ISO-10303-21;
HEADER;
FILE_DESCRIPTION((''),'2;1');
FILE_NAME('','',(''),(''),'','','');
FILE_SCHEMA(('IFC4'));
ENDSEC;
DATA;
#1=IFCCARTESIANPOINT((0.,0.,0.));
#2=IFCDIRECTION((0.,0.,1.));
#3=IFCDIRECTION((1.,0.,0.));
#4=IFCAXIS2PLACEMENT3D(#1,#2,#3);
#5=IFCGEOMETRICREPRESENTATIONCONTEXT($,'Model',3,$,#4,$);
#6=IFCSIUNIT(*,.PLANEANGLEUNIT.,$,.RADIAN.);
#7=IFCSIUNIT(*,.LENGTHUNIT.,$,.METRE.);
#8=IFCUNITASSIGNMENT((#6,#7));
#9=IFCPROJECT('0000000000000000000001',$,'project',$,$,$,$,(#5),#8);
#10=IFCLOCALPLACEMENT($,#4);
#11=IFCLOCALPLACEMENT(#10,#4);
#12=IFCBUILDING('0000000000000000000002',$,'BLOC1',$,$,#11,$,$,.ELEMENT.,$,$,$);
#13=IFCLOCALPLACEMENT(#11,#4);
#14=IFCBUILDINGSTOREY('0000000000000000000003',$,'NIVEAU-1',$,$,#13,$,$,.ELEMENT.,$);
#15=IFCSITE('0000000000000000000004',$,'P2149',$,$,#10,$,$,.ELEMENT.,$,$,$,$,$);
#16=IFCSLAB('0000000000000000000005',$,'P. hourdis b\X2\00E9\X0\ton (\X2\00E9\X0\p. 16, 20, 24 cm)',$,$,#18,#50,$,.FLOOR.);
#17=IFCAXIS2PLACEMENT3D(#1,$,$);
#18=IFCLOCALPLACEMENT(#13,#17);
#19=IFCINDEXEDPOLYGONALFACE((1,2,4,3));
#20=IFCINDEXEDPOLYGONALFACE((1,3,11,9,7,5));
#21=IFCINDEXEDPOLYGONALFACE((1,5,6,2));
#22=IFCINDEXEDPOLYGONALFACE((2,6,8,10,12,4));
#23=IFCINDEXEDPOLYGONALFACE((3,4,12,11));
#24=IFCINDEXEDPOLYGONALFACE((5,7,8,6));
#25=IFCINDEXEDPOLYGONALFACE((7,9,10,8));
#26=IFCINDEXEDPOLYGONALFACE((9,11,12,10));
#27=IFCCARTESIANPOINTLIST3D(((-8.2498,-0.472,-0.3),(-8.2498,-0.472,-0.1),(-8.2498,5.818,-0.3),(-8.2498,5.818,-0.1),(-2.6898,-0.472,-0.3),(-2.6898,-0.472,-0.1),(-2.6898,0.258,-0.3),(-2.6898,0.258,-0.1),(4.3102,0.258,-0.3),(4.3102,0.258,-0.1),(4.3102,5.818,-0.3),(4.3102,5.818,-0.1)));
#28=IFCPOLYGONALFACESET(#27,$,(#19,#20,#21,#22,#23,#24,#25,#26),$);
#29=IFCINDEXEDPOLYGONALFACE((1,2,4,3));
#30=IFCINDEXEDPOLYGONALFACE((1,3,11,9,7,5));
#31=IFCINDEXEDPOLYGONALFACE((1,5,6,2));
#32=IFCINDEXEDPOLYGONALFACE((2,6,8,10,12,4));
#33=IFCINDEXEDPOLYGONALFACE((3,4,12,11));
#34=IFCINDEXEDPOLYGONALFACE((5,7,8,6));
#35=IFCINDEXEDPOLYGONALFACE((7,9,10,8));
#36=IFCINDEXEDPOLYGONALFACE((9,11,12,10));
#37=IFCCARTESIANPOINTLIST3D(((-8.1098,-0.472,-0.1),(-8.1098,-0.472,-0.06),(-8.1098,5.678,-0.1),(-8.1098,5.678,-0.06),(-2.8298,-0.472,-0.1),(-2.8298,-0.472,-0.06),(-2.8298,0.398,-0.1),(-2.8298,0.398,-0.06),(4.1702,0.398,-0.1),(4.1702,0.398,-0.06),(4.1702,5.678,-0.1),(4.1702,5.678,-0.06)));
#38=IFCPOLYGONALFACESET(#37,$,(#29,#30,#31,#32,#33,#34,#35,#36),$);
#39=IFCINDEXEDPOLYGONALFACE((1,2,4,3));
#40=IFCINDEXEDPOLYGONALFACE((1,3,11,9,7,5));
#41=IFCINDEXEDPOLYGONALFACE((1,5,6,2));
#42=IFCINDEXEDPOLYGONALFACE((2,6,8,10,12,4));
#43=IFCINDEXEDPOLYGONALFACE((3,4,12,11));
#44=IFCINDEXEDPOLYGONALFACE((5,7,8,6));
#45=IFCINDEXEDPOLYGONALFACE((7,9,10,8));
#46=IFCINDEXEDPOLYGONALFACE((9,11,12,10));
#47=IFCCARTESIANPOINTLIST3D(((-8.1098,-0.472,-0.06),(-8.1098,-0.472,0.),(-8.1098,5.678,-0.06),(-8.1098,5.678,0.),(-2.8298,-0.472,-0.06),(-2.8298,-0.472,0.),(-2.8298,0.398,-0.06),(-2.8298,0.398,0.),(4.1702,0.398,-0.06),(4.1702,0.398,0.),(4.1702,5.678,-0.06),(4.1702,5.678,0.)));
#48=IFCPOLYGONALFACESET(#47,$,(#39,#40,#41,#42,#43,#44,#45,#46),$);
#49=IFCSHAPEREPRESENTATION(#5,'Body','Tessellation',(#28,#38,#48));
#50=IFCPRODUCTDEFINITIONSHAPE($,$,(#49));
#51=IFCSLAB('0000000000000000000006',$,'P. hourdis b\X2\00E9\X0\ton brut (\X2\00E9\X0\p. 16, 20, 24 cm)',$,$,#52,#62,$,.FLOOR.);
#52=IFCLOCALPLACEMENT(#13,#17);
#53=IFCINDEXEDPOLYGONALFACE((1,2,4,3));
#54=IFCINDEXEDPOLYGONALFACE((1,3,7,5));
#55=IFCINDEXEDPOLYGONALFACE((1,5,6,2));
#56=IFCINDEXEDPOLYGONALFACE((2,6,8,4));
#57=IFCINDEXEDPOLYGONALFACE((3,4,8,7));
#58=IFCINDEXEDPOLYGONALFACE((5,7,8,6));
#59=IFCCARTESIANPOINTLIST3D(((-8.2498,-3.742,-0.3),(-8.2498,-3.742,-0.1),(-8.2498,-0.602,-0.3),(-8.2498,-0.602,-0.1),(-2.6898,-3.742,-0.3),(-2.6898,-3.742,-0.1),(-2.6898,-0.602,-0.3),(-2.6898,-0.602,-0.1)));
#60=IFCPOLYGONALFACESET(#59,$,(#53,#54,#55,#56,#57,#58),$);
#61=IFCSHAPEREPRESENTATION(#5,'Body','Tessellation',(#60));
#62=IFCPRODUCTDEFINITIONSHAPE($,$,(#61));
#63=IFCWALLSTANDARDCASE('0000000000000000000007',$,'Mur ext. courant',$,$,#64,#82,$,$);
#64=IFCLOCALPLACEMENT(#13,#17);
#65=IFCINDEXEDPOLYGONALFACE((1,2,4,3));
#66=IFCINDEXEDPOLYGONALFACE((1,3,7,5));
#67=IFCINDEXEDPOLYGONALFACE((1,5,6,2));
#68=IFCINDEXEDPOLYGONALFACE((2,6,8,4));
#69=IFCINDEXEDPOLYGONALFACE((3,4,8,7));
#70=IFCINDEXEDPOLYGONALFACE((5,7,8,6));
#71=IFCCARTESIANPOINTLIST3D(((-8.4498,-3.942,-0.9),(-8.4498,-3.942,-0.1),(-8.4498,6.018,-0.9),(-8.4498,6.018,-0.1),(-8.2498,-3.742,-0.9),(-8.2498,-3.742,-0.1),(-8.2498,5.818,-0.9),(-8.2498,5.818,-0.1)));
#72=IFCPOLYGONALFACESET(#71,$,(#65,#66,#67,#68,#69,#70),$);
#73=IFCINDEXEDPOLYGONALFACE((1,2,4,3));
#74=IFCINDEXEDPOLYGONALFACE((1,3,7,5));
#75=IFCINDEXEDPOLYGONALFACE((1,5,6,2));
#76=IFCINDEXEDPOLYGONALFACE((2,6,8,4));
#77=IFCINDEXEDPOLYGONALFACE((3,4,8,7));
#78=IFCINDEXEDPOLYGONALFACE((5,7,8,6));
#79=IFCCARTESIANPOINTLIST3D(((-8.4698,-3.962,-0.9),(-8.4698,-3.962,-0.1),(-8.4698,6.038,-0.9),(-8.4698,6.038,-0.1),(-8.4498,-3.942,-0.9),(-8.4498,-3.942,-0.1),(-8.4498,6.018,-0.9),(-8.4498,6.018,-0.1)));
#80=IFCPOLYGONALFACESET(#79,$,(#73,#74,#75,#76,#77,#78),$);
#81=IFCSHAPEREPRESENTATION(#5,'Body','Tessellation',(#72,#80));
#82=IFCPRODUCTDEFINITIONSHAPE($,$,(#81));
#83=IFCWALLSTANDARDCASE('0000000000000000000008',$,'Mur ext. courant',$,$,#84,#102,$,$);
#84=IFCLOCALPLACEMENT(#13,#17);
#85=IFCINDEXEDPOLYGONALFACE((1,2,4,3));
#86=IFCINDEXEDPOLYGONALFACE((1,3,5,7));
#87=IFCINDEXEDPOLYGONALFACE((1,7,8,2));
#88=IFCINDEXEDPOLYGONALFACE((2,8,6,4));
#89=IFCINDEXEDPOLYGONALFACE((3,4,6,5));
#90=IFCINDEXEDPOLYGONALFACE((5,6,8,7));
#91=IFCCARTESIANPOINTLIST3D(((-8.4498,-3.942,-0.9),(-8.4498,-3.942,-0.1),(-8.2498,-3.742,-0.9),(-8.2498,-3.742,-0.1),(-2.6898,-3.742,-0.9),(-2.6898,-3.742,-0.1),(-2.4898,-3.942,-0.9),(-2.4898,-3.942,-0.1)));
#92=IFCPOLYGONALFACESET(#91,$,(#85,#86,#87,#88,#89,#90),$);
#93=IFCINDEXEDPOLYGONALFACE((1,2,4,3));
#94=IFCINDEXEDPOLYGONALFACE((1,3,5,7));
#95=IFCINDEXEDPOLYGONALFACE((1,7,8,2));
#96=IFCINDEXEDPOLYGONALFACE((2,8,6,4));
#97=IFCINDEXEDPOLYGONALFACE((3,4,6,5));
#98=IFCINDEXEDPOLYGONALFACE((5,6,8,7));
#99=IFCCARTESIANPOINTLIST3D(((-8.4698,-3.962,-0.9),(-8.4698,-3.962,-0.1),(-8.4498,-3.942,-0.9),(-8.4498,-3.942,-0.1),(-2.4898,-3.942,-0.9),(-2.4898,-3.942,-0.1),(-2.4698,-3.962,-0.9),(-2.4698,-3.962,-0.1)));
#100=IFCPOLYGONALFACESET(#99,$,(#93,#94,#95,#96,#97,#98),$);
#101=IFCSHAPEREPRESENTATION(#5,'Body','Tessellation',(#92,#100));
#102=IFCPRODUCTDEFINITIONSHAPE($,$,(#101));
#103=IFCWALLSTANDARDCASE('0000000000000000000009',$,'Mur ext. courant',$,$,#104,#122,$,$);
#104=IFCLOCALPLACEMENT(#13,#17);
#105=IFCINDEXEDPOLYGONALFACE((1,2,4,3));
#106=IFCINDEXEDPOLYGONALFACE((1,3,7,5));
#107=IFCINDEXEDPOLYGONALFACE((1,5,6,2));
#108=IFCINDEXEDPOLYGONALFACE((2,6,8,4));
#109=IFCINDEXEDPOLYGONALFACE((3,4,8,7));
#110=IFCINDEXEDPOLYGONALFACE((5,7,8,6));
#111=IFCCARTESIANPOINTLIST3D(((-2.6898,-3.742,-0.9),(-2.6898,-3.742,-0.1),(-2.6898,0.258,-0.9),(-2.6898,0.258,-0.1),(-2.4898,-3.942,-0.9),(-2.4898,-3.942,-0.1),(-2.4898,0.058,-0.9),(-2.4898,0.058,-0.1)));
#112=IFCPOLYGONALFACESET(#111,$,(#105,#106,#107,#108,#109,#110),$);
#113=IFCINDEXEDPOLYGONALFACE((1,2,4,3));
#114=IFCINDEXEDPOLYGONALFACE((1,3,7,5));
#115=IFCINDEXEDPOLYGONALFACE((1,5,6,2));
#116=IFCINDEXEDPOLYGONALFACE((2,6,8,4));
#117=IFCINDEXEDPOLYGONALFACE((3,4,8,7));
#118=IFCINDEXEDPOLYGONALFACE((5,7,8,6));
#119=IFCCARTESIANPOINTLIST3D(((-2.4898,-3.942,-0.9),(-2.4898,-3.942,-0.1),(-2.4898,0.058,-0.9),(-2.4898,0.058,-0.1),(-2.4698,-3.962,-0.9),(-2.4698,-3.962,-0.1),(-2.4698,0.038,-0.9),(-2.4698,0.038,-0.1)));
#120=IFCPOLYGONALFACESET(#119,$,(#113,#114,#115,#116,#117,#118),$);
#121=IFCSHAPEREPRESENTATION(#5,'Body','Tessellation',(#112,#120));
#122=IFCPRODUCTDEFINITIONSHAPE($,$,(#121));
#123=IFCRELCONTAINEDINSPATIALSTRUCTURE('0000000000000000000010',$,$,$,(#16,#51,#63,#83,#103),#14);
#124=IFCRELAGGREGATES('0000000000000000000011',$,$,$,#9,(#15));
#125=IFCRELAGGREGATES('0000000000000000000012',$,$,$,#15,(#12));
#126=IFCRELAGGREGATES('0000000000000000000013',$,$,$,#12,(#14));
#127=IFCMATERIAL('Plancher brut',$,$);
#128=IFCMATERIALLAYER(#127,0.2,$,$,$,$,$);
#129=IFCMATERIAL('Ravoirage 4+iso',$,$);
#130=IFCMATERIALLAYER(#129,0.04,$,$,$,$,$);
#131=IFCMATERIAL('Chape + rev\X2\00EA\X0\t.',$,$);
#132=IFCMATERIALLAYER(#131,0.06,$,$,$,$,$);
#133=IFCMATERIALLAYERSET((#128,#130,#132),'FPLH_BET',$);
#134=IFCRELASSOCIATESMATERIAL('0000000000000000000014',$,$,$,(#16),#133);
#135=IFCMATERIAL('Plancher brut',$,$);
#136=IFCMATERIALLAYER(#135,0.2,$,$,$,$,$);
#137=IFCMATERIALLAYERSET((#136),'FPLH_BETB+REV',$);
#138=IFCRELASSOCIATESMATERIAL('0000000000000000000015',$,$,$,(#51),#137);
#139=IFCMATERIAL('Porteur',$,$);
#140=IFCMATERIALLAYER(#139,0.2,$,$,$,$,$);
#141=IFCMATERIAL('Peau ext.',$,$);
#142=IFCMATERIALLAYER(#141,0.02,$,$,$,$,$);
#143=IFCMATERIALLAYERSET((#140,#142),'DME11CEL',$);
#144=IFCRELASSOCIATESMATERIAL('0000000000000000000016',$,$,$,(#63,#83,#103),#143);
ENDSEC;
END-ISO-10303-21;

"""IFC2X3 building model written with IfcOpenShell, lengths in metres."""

from ifc_helpers import new_model, si_unit, point, frame, origin_with_axes, place, context, project, spatial, line_curve, trimmed, segment, composite_curve, outline, extrude, material, layer, layer_set, layer_usage, element, save


model = new_model("IFC2X3")

# Units and contexts
model_context = context("Model", 3, world=origin_with_axes())
ifc_project = project(units=[si_unit("PLANEANGLEUNIT", "RADIAN"), si_unit("LENGTHUNIT", "METRE")], contexts=[model_context])

# Site, building, storey
site_placement = place(None, origin_with_axes())
site = spatial("IfcSite", under=ifc_project, at=site_placement, Name="P2149", CompositionType="ELEMENT")
building_placement = place(site_placement, origin_with_axes())
building = spatial("IfcBuilding", under=site, at=building_placement, Name="BLOC1", CompositionType="ELEMENT")
storey_placement = place(building_placement, origin_with_axes())
storey = spatial("IfcBuildingStorey", under=building, at=storey_placement, Name="NIVEAU-1", CompositionType="ELEMENT")

# Slabs
ifc_material_1 = material(Name="Plancher brut")
ifc_layer_1 = layer(ifc_material_1, 0.2)
ifc_material_2 = material(Name="Ravoirage 4+iso")
ifc_layer_2 = layer(ifc_material_2, 0.04)
ifc_material_3 = material(Name="Chape + revêt.")
ifc_layer_3 = layer(ifc_material_3, 0.06)
ifc_layer_set_1 = layer_set([ifc_layer_1, ifc_layer_2, ifc_layer_3], Name="FPLH_BET")
ifc_layer_usage_1 = layer_usage(ifc_layer_set_1, "AXIS3", "POSITIVE", 0.0)
slab_1_placement = place(storey_placement, origin_with_axes())
element("IfcSlab", 1, at=slab_1_placement, inside=storey, material=ifc_layer_usage_1, Name="P. hourdis béton (ép. 16, 20, 24 cm)", PredefinedType="FLOOR", context=model_context, shape_type="SweptSolid", body=[
    extrude(outline(composite_curve([segment(trimmed(line_curve((-2.6898, 0.258), (1.0, 0.0), 7.0), [point((-2.6898, 0.258))], [point((4.3102, 0.258))], True, "CARTESIAN"), True, "CONTINUOUS"), segment(trimmed(line_curve((4.3102, 0.258), (0.0, 1.0), 5.56), [point((4.3102, 0.258))], [point((4.3102, 5.818))], True, "CARTESIAN"), True, "CONTINUOUS"), segment(trimmed(line_curve((4.3102, 5.818), (-1.0, 0.0), 12.56), [point((4.3102, 5.818))], [point((-8.2498, 5.818))], True, "CARTESIAN"), True, "CONTINUOUS"), segment(trimmed(line_curve((-8.2498, 5.818), (0.0, -1.0), 6.29), [point((-8.2498, 5.818))], [point((-8.2498, -0.472))], True, "CARTESIAN"), True, "CONTINUOUS"), segment(trimmed(line_curve((-8.2498, -0.472), (1.0, 0.0), 5.56), [point((-8.2498, -0.472))], [point((-2.6898, -0.472))], True, "CARTESIAN"), True, "CONTINUOUS"), segment(trimmed(line_curve((-2.6898, -0.472), (0.0, 1.0), 0.73), [point((-2.6898, -0.472))], [point((-2.6898, 0.258))], True, "CARTESIAN"), True, "CONTINUOUS")], self_intersect=False)), frame((0.0, 0.0, -0.3), z_axis=(0.0, 0.0, 1.0), x_axis=(1.0, 0.0, 0.0)), (0.0, 0.0, 1.0), 0.2),
    extrude(outline(composite_curve([segment(trimmed(line_curve((-2.8298, 0.398), (1.0, 0.0), 7.0), [point((-2.8298, 0.398))], [point((4.1702, 0.398))], True, "CARTESIAN"), True, "CONTINUOUS"), segment(trimmed(line_curve((4.1702, 0.398), (0.0, 1.0), 5.28), [point((4.1702, 0.398))], [point((4.1702, 5.678))], True, "CARTESIAN"), True, "CONTINUOUS"), segment(trimmed(line_curve((4.1702, 5.678), (-1.0, 0.0), 12.28), [point((4.1702, 5.678))], [point((-8.1098, 5.678))], True, "CARTESIAN"), True, "CONTINUOUS"), segment(trimmed(line_curve((-8.1098, 5.678), (0.0, -1.0), 6.15), [point((-8.1098, 5.678))], [point((-8.1098, -0.472))], True, "CARTESIAN"), True, "CONTINUOUS"), segment(trimmed(line_curve((-8.1098, -0.472), (1.0, 0.0), 5.28), [point((-8.1098, -0.472))], [point((-2.8298, -0.472))], True, "CARTESIAN"), True, "CONTINUOUS"), segment(trimmed(line_curve((-2.8298, -0.472), (0.0, 1.0), 0.87), [point((-2.8298, -0.472))], [point((-2.8298, 0.398))], True, "CARTESIAN"), True, "CONTINUOUS")], self_intersect=False)), frame((0.0, 0.0, -0.1), z_axis=(0.0, 0.0, 1.0), x_axis=(1.0, 0.0, 0.0)), (0.0, 0.0, 1.0), 0.04),
    extrude(outline(composite_curve([segment(trimmed(line_curve((-2.8298, 0.398), (1.0, 0.0), 7.0), [point((-2.8298, 0.398))], [point((4.1702, 0.398))], True, "CARTESIAN"), True, "CONTINUOUS"), segment(trimmed(line_curve((4.1702, 0.398), (0.0, 1.0), 5.28), [point((4.1702, 0.398))], [point((4.1702, 5.678))], True, "CARTESIAN"), True, "CONTINUOUS"), segment(trimmed(line_curve((4.1702, 5.678), (-1.0, 0.0), 12.28), [point((4.1702, 5.678))], [point((-8.1098, 5.678))], True, "CARTESIAN"), True, "CONTINUOUS"), segment(trimmed(line_curve((-8.1098, 5.678), (0.0, -1.0), 6.15), [point((-8.1098, 5.678))], [point((-8.1098, -0.472))], True, "CARTESIAN"), True, "CONTINUOUS"), segment(trimmed(line_curve((-8.1098, -0.472), (1.0, 0.0), 5.28), [point((-8.1098, -0.472))], [point((-2.8298, -0.472))], True, "CARTESIAN"), True, "CONTINUOUS"), segment(trimmed(line_curve((-2.8298, -0.472), (0.0, 1.0), 0.87), [point((-2.8298, -0.472))], [point((-2.8298, 0.398))], True, "CARTESIAN"), True, "CONTINUOUS")], self_intersect=False)), frame((0.0, 0.0, -0.06), z_axis=(0.0, 0.0, 1.0), x_axis=(1.0, 0.0, 0.0)), (0.0, 0.0, 1.0), 0.06),
])
ifc_material_4 = material(Name="Plancher brut")
ifc_layer_4 = layer(ifc_material_4, 0.2)
ifc_layer_set_2 = layer_set([ifc_layer_4], Name="FPLH_BETB+REV")
ifc_layer_usage_2 = layer_usage(ifc_layer_set_2, "AXIS3", "POSITIVE", 0.0)
slab_2_placement = place(storey_placement, origin_with_axes())
element("IfcSlab", 2, at=slab_2_placement, inside=storey, material=ifc_layer_usage_2, Name="P. hourdis béton brut (ép. 16, 20, 24 cm)", PredefinedType="FLOOR", context=model_context, shape_type="SweptSolid", body=[
    extrude(outline(composite_curve([segment(trimmed(line_curve((-8.2498, -3.742), (1.0, 0.0), 5.56), [point((-8.2498, -3.742))], [point((-2.6898, -3.742))], True, "CARTESIAN"), True, "CONTINUOUS"), segment(trimmed(line_curve((-2.6898, -3.742), (0.0, 1.0), 3.14), [point((-2.6898, -3.742))], [point((-2.6898, -0.602))], True, "CARTESIAN"), True, "CONTINUOUS"), segment(trimmed(line_curve((-2.6898, -0.602), (-1.0, 0.0), 5.56), [point((-2.6898, -0.602))], [point((-8.2498, -0.602))], True, "CARTESIAN"), True, "CONTINUOUS"), segment(trimmed(line_curve((-8.2498, -0.602), (0.0, -1.0), 3.14), [point((-8.2498, -0.602))], [point((-8.2498, -3.742))], True, "CARTESIAN"), True, "CONTINUOUS")], self_intersect=False)), frame((0.0, 0.0, -0.3), z_axis=(0.0, 0.0, 1.0), x_axis=(1.0, 0.0, 0.0)), (0.0, 0.0, 1.0), 0.2),
])

# Walls
ifc_material_5 = material(Name="Porteur")
ifc_layer_5 = layer(ifc_material_5, 0.2)
ifc_material_6 = material(Name="Peau ext.")
ifc_layer_6 = layer(ifc_material_6, 0.02)
ifc_layer_set_3 = layer_set([ifc_layer_5, ifc_layer_6], Name="DME11CEL")
ifc_layer_usage_3 = layer_usage(ifc_layer_set_3, "AXIS2", "POSITIVE", 0.0)
wall_1_placement = place(storey_placement, frame((-8.2498, -3.742, -0.9), z_axis=(0.0, 0.0, 1.0), x_axis=(0.0, 1.0, 0.0)))
element("IfcWallStandardCase", 3, at=wall_1_placement, inside=storey, material=ifc_layer_usage_3, Name="Mur ext. courant", context=model_context, shape_type="SweptSolid", body=[
    extrude(outline(composite_curve([segment(trimmed(line_curve((0.0, 0.0), (1.0, 0.0), 9.56), [point((0.0, 0.0))], [point((9.56, 0.0))], True, "CARTESIAN"), True, "CONTINUOUS"), segment(trimmed(line_curve((9.56, 0.0), (0.707107, 0.707107), 0.282843), [point((9.56, 0.0))], [point((9.76, 0.2))], True, "CARTESIAN"), True, "CONTINUOUS"), segment(trimmed(line_curve((9.76, 0.2), (-1.0, 0.0), 9.96), [point((9.76, 0.2))], [point((-0.2, 0.2))], True, "CARTESIAN"), True, "CONTINUOUS"), segment(trimmed(line_curve((-0.2, 0.2), (0.707107, -0.707107), 0.282843), [point((-0.2, 0.2))], [point((0.0, 0.0))], True, "CARTESIAN"), True, "CONTINUOUS")], self_intersect=False)), origin_with_axes(), (0.0, 0.0, 1.0), 0.8),
    extrude(outline(composite_curve([segment(trimmed(line_curve((-0.2, 0.2), (1.0, 0.0), 9.96), [point((-0.2, 0.2))], [point((9.76, 0.2))], True, "CARTESIAN"), True, "CONTINUOUS"), segment(trimmed(line_curve((9.76, 0.2), (0.707107, 0.707107), 0.028284), [point((9.76, 0.2))], [point((9.78, 0.22))], True, "CARTESIAN"), True, "CONTINUOUS"), segment(trimmed(line_curve((9.78, 0.22), (-1.0, 0.0), 10.0), [point((9.78, 0.22))], [point((-0.22, 0.22))], True, "CARTESIAN"), True, "CONTINUOUS"), segment(trimmed(line_curve((-0.22, 0.22), (0.707107, -0.707107), 0.028284), [point((-0.22, 0.22))], [point((-0.2, 0.2))], True, "CARTESIAN"), True, "CONTINUOUS")], self_intersect=False)), origin_with_axes(), (0.0, 0.0, 1.0), 0.8),
])
wall_2_placement = place(storey_placement, frame((-2.6898, -3.742, -0.9), z_axis=(0.0, 0.0, 1.0), x_axis=(-1.0, 0.0, 0.0)))
element("IfcWallStandardCase", 4, at=wall_2_placement, inside=storey, material=ifc_layer_usage_3, Name="Mur ext. courant", context=model_context, shape_type="SweptSolid", body=[
    extrude(outline(composite_curve([segment(trimmed(line_curve((0.0, 0.0), (1.0, 0.0), 5.56), [point((0.0, 0.0))], [point((5.56, 0.0))], True, "CARTESIAN"), True, "CONTINUOUS"), segment(trimmed(line_curve((5.56, 0.0), (0.707107, 0.707107), 0.282843), [point((5.56, 0.0))], [point((5.76, 0.2))], True, "CARTESIAN"), True, "CONTINUOUS"), segment(trimmed(line_curve((5.76, 0.2), (-1.0, 0.0), 5.96), [point((5.76, 0.2))], [point((-0.2, 0.2))], True, "CARTESIAN"), True, "CONTINUOUS"), segment(trimmed(line_curve((-0.2, 0.2), (0.707107, -0.707107), 0.282843), [point((-0.2, 0.2))], [point((0.0, 0.0))], True, "CARTESIAN"), True, "CONTINUOUS")], self_intersect=False)), origin_with_axes(), (0.0, 0.0, 1.0), 0.8),
    extrude(outline(composite_curve([segment(trimmed(line_curve((-0.2, 0.2), (1.0, 0.0), 5.96), [point((-0.2, 0.2))], [point((5.76, 0.2))], True, "CARTESIAN"), True, "CONTINUOUS"), segment(trimmed(line_curve((5.76, 0.2), (0.707107, 0.707107), 0.028284), [point((5.76, 0.2))], [point((5.78, 0.22))], True, "CARTESIAN"), True, "CONTINUOUS"), segment(trimmed(line_curve((5.78, 0.22), (-1.0, 0.0), 6.0), [point((5.78, 0.22))], [point((-0.22, 0.22))], True, "CARTESIAN"), True, "CONTINUOUS"), segment(trimmed(line_curve((-0.22, 0.22), (0.707107, -0.707107), 0.028284), [point((-0.22, 0.22))], [point((-0.2, 0.2))], True, "CARTESIAN"), True, "CONTINUOUS")], self_intersect=False)), origin_with_axes(), (0.0, 0.0, 1.0), 0.8),
])
wall_3_placement = place(storey_placement, frame((-2.6898, 0.258, -0.9), z_axis=(0.0, 0.0, 1.0), x_axis=(0.0, -1.0, 0.0)))
element("IfcWallStandardCase", 5, at=wall_3_placement, inside=storey, material=ifc_layer_usage_3, Name="Mur ext. courant", context=model_context, shape_type="SweptSolid", body=[
    extrude(outline(composite_curve([segment(trimmed(line_curve((0.0, 0.0), (1.0, 0.0), 4.0), [point((0.0, 0.0))], [point((4.0, 0.0))], True, "CARTESIAN"), True, "CONTINUOUS"), segment(trimmed(line_curve((4.0, 0.0), (0.707107, 0.707107), 0.282843), [point((4.0, 0.0))], [point((4.2, 0.2))], True, "CARTESIAN"), True, "CONTINUOUS"), segment(trimmed(line_curve((4.2, 0.2), (-1.0, 0.0), 4.0), [point((4.2, 0.2))], [point((0.2, 0.2))], True, "CARTESIAN"), True, "CONTINUOUS"), segment(trimmed(line_curve((0.2, 0.2), (-0.707107, -0.707107), 0.282843), [point((0.2, 0.2))], [point((0.0, 0.0))], True, "CARTESIAN"), True, "CONTINUOUS")], self_intersect=False)), origin_with_axes(), (0.0, 0.0, 1.0), 0.8),
    extrude(outline(composite_curve([segment(trimmed(line_curve((0.2, 0.2), (1.0, 0.0), 4.0), [point((0.2, 0.2))], [point((4.2, 0.2))], True, "CARTESIAN"), True, "CONTINUOUS"), segment(trimmed(line_curve((4.2, 0.2), (0.707107, 0.707107), 0.028284), [point((4.2, 0.2))], [point((4.22, 0.22))], True, "CARTESIAN"), True, "CONTINUOUS"), segment(trimmed(line_curve((4.22, 0.22), (-1.0, 0.0), 4.0), [point((4.22, 0.22))], [point((0.22, 0.22))], True, "CARTESIAN"), True, "CONTINUOUS"), segment(trimmed(line_curve((0.22, 0.22), (-0.707107, -0.707107), 0.028284), [point((0.22, 0.22))], [point((0.2, 0.2))], True, "CARTESIAN"), True, "CONTINUOUS")], self_intersect=False)), origin_with_axes(), (0.0, 0.0, 1.0), 0.8),
])

save(model, "model.ifc")
